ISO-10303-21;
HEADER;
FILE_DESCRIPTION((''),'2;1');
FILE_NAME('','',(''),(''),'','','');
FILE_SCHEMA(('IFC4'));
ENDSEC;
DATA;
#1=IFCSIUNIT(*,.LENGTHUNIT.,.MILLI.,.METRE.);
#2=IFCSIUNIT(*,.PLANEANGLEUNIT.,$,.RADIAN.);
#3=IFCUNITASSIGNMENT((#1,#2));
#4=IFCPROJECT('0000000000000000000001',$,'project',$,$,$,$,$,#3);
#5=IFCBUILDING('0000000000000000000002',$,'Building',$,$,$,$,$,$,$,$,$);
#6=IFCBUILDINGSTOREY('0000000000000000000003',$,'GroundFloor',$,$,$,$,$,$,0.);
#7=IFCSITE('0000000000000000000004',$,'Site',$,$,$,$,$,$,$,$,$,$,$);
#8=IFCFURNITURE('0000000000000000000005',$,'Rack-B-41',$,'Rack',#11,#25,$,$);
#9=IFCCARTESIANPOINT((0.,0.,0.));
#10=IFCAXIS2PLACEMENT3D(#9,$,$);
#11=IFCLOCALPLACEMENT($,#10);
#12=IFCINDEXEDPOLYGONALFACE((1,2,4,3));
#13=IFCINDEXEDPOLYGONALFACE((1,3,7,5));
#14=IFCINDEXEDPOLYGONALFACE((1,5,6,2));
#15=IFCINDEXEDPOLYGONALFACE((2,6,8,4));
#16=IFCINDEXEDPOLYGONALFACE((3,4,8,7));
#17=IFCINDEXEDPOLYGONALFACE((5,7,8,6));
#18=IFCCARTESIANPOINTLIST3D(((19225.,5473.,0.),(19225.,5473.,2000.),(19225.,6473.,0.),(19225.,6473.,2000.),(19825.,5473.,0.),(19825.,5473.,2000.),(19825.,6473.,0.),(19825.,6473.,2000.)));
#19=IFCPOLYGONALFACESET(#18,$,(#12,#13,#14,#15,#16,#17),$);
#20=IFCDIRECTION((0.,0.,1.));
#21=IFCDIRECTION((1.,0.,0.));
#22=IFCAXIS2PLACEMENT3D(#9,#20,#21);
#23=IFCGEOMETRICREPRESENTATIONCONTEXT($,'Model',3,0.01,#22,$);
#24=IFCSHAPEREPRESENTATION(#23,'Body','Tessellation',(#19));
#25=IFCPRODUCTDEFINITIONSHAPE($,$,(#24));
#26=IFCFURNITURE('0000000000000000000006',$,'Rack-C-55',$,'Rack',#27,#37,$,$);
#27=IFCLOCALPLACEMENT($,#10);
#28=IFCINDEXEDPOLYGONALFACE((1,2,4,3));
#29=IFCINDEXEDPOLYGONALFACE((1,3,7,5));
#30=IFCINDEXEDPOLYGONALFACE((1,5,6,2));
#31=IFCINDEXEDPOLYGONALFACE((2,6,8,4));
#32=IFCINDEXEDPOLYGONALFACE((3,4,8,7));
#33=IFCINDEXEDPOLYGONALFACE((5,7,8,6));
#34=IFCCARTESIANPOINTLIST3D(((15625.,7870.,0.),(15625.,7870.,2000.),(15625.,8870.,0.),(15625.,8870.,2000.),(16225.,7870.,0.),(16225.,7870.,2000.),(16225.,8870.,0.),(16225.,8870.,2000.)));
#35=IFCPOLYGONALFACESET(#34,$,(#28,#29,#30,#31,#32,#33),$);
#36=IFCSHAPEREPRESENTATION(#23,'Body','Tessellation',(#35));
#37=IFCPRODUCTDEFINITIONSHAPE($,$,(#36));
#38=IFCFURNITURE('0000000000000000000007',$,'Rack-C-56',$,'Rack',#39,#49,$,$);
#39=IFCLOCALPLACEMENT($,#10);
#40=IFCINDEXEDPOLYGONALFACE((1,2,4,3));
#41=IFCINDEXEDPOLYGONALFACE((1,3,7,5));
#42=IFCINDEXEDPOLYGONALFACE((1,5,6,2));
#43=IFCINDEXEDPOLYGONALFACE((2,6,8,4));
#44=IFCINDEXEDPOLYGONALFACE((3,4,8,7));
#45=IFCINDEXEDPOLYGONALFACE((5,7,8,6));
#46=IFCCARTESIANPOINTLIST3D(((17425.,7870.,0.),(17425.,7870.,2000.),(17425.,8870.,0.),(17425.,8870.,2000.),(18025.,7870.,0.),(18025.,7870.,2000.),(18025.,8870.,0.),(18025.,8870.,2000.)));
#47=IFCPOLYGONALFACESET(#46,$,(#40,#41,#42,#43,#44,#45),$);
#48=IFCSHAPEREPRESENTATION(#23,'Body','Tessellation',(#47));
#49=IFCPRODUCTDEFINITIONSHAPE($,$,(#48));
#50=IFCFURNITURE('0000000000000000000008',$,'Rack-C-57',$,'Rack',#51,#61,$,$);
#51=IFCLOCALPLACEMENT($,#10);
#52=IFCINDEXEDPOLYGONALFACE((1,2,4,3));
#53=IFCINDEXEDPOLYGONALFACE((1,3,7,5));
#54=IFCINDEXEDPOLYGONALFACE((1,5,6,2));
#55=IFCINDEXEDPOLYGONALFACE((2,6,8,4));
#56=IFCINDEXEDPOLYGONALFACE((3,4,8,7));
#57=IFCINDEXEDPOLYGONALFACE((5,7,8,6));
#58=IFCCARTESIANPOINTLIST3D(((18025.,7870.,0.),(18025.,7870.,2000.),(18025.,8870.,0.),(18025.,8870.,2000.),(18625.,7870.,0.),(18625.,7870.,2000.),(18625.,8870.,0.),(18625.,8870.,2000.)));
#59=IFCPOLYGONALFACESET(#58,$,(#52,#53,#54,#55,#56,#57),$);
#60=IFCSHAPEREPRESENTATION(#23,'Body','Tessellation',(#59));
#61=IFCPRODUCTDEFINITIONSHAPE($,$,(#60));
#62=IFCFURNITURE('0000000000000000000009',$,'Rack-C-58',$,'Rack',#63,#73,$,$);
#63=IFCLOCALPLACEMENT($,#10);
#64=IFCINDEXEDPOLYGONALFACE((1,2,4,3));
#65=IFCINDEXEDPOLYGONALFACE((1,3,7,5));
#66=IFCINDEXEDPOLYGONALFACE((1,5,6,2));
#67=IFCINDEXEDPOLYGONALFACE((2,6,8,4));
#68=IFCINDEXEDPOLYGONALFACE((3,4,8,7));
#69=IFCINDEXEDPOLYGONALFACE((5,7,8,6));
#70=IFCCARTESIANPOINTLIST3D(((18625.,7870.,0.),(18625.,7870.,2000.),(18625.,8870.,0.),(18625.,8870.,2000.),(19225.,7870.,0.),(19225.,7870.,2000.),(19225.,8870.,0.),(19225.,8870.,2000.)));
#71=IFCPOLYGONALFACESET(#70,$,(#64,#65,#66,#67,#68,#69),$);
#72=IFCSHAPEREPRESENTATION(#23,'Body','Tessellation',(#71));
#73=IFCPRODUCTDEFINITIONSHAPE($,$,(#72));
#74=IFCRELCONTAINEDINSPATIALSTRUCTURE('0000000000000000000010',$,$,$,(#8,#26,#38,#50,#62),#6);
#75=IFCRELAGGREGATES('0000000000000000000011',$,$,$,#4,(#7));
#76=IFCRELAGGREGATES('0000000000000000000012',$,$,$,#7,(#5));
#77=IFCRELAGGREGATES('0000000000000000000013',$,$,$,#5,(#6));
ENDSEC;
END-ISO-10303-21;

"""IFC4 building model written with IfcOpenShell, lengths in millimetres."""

from ifc_helpers import new_model, si_unit, frame, origin, origin_with_axes, origin_2d, place, context, project, spatial, rectangle, extrude, element, save


model = new_model("IFC4")

# Units and contexts
model_context = context("Model", 3, precision=0.01, world=origin_with_axes())
ifc_project = project(units=[si_unit("LENGTHUNIT", "METRE", prefix="MILLI"), si_unit("PLANEANGLEUNIT", "RADIAN")])

# Site, building, storey
site = spatial("IfcSite", under=ifc_project, Name="Site")
building = spatial("IfcBuilding", under=site, Name="Building")
storey = spatial("IfcBuildingStorey", under=building, Name="GroundFloor", Elevation=0.0)

# Furniture
for number, where, z_axis, x_axis, name in (
    (1, (19525.0, 5973.0, 0.0), (0.0, 0.0, 1.0), (1.0, 0.0, 0.0), "Rack-B-41"),
    (2, (15925.0, 8370.0, 0.0), (0.0, 0.0, 1.0), (1.0, 0.0, 0.0), "Rack-C-55"),
    (3, (17725.0, 8370.0, 0.0), (0.0, 0.0, 1.0), (1.0, 0.0, 0.0), "Rack-C-56"),
    (4, (18325.0, 8370.0, 0.0), (0.0, 0.0, 1.0), (1.0, 0.0, 0.0), "Rack-C-57"),
    (5, (18925.0, 8370.0, 0.0), (0.0, 0.0, 1.0), (1.0, 0.0, 0.0), "Rack-C-58"),
):
    element("IfcFurniture", number, at=place(None, frame(where, z_axis=z_axis, x_axis=x_axis)), inside=storey, Name=name, ObjectType="Rack", context=model_context, shape_type="SweptSolid", body=[
        extrude(rectangle(XDim=600.0, YDim=1000.0, at=origin_2d()), origin(), (0.0, 0.0, 1.0), 2000.0),
    ])

save(model, "model.ifc")
